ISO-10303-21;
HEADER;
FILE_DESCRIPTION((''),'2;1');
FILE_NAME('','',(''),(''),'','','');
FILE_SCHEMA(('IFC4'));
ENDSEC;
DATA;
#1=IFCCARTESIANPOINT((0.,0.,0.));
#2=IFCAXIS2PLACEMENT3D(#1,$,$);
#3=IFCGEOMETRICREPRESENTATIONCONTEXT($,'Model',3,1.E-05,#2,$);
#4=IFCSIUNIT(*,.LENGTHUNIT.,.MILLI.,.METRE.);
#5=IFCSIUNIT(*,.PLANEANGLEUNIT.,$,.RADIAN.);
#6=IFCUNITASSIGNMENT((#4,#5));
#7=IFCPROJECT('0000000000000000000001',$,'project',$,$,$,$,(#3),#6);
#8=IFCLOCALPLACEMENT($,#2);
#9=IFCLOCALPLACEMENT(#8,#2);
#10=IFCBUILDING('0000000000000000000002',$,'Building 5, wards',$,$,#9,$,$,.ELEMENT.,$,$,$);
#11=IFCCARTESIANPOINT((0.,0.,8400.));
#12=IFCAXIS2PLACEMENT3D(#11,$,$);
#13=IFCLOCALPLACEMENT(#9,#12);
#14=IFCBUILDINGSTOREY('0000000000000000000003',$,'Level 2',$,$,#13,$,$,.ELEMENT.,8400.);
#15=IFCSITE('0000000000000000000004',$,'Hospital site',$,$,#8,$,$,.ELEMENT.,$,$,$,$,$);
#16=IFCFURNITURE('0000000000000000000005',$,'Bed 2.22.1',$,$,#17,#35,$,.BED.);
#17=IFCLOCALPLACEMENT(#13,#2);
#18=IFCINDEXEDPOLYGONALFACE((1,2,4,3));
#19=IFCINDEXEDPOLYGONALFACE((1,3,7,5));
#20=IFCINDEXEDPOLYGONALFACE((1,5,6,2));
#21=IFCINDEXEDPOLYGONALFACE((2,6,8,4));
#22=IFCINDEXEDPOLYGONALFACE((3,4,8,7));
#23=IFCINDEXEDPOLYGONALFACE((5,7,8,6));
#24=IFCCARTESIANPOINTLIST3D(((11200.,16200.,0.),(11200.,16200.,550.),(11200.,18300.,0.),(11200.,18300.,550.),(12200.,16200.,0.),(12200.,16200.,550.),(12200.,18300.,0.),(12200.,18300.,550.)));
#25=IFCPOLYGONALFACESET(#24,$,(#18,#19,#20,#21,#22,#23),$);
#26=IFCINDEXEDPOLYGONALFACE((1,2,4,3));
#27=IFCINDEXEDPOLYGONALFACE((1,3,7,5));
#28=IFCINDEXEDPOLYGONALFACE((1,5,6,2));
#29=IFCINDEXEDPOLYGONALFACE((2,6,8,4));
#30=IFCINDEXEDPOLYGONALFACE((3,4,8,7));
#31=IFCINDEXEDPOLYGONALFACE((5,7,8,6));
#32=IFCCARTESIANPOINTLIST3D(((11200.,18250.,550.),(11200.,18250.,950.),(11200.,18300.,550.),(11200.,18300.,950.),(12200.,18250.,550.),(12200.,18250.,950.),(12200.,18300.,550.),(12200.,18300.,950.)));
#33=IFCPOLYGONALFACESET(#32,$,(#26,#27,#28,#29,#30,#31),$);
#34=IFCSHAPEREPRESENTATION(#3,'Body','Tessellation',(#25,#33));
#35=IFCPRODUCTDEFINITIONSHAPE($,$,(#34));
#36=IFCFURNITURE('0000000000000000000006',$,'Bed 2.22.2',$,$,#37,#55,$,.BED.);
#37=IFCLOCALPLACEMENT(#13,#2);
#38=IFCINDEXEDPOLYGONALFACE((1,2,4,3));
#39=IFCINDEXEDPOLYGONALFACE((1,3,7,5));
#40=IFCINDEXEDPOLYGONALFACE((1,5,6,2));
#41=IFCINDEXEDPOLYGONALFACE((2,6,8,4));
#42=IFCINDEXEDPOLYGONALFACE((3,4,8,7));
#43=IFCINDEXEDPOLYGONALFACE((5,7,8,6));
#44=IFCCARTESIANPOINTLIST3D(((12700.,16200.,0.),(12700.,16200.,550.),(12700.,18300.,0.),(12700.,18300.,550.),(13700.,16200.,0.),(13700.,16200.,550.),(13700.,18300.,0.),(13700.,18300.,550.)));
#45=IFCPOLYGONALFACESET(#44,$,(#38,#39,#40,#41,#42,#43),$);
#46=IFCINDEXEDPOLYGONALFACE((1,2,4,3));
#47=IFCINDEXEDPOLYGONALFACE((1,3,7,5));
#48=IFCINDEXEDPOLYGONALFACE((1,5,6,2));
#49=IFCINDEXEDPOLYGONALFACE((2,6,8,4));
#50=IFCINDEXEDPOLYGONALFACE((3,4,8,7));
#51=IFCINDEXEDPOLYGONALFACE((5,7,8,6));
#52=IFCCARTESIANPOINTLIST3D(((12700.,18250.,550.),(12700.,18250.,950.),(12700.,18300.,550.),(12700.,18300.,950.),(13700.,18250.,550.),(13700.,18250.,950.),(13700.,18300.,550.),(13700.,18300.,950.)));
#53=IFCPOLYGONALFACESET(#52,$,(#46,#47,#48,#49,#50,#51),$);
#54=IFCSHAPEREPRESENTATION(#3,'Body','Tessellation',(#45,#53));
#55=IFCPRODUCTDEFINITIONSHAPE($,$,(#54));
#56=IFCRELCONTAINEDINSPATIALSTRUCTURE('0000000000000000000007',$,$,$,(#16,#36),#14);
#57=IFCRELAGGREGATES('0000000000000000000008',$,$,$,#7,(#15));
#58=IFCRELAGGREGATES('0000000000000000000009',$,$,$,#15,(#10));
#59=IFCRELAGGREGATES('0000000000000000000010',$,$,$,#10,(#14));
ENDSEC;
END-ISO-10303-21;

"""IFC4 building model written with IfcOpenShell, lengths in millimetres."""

from ifc_helpers import new_model, si_unit, frame, frame_2d, origin, place, context, project, spatial, rectangle, extrude, element, save


model = new_model("IFC4")

# Units and contexts
model_context = context("Model", 3, precision=1e-05, world=origin())
ifc_project = project(units=[si_unit("LENGTHUNIT", "METRE", prefix="MILLI"), si_unit("PLANEANGLEUNIT", "RADIAN")], contexts=[model_context])

# Site, building, storey
site_placement = place(None, origin())
site = spatial("IfcSite", under=ifc_project, at=site_placement, Name="Hospital site", CompositionType="ELEMENT")
building_placement = place(site_placement, origin())
building = spatial("IfcBuilding", under=site, at=building_placement, Name="Building 5, wards", CompositionType="ELEMENT")
storey_placement = place(building_placement, frame((0.0, 0.0, 8400.0)))
storey = spatial("IfcBuildingStorey", under=building, at=storey_placement, Name="Level 2", CompositionType="ELEMENT", Elevation=8400.0)

# Furniture
for number, where, name in (
    (1, (11200.0, 16200.0, 0.0), "Bed 2.22.1"),
    (2, (12700.0, 16200.0, 0.0), "Bed 2.22.2"),
):
    element("IfcFurniture", number, at=place(storey_placement, frame(where)), inside=storey, Name=name, PredefinedType="BED", context=model_context, shape_type="SweptSolid", body=[
        extrude(rectangle(XDim=1000.0, YDim=2100.0, at=frame_2d((500.0, 1050.0))), origin(), (0.0, 0.0, 1.0), 550.0),
        extrude(rectangle(XDim=1000.0, YDim=50.0, at=frame_2d((500.0, 2075.0))), frame((0.0, 0.0, 550.0)), (0.0, 0.0, 1.0), 400.0),
    ])

save(model, "model.ifc")
